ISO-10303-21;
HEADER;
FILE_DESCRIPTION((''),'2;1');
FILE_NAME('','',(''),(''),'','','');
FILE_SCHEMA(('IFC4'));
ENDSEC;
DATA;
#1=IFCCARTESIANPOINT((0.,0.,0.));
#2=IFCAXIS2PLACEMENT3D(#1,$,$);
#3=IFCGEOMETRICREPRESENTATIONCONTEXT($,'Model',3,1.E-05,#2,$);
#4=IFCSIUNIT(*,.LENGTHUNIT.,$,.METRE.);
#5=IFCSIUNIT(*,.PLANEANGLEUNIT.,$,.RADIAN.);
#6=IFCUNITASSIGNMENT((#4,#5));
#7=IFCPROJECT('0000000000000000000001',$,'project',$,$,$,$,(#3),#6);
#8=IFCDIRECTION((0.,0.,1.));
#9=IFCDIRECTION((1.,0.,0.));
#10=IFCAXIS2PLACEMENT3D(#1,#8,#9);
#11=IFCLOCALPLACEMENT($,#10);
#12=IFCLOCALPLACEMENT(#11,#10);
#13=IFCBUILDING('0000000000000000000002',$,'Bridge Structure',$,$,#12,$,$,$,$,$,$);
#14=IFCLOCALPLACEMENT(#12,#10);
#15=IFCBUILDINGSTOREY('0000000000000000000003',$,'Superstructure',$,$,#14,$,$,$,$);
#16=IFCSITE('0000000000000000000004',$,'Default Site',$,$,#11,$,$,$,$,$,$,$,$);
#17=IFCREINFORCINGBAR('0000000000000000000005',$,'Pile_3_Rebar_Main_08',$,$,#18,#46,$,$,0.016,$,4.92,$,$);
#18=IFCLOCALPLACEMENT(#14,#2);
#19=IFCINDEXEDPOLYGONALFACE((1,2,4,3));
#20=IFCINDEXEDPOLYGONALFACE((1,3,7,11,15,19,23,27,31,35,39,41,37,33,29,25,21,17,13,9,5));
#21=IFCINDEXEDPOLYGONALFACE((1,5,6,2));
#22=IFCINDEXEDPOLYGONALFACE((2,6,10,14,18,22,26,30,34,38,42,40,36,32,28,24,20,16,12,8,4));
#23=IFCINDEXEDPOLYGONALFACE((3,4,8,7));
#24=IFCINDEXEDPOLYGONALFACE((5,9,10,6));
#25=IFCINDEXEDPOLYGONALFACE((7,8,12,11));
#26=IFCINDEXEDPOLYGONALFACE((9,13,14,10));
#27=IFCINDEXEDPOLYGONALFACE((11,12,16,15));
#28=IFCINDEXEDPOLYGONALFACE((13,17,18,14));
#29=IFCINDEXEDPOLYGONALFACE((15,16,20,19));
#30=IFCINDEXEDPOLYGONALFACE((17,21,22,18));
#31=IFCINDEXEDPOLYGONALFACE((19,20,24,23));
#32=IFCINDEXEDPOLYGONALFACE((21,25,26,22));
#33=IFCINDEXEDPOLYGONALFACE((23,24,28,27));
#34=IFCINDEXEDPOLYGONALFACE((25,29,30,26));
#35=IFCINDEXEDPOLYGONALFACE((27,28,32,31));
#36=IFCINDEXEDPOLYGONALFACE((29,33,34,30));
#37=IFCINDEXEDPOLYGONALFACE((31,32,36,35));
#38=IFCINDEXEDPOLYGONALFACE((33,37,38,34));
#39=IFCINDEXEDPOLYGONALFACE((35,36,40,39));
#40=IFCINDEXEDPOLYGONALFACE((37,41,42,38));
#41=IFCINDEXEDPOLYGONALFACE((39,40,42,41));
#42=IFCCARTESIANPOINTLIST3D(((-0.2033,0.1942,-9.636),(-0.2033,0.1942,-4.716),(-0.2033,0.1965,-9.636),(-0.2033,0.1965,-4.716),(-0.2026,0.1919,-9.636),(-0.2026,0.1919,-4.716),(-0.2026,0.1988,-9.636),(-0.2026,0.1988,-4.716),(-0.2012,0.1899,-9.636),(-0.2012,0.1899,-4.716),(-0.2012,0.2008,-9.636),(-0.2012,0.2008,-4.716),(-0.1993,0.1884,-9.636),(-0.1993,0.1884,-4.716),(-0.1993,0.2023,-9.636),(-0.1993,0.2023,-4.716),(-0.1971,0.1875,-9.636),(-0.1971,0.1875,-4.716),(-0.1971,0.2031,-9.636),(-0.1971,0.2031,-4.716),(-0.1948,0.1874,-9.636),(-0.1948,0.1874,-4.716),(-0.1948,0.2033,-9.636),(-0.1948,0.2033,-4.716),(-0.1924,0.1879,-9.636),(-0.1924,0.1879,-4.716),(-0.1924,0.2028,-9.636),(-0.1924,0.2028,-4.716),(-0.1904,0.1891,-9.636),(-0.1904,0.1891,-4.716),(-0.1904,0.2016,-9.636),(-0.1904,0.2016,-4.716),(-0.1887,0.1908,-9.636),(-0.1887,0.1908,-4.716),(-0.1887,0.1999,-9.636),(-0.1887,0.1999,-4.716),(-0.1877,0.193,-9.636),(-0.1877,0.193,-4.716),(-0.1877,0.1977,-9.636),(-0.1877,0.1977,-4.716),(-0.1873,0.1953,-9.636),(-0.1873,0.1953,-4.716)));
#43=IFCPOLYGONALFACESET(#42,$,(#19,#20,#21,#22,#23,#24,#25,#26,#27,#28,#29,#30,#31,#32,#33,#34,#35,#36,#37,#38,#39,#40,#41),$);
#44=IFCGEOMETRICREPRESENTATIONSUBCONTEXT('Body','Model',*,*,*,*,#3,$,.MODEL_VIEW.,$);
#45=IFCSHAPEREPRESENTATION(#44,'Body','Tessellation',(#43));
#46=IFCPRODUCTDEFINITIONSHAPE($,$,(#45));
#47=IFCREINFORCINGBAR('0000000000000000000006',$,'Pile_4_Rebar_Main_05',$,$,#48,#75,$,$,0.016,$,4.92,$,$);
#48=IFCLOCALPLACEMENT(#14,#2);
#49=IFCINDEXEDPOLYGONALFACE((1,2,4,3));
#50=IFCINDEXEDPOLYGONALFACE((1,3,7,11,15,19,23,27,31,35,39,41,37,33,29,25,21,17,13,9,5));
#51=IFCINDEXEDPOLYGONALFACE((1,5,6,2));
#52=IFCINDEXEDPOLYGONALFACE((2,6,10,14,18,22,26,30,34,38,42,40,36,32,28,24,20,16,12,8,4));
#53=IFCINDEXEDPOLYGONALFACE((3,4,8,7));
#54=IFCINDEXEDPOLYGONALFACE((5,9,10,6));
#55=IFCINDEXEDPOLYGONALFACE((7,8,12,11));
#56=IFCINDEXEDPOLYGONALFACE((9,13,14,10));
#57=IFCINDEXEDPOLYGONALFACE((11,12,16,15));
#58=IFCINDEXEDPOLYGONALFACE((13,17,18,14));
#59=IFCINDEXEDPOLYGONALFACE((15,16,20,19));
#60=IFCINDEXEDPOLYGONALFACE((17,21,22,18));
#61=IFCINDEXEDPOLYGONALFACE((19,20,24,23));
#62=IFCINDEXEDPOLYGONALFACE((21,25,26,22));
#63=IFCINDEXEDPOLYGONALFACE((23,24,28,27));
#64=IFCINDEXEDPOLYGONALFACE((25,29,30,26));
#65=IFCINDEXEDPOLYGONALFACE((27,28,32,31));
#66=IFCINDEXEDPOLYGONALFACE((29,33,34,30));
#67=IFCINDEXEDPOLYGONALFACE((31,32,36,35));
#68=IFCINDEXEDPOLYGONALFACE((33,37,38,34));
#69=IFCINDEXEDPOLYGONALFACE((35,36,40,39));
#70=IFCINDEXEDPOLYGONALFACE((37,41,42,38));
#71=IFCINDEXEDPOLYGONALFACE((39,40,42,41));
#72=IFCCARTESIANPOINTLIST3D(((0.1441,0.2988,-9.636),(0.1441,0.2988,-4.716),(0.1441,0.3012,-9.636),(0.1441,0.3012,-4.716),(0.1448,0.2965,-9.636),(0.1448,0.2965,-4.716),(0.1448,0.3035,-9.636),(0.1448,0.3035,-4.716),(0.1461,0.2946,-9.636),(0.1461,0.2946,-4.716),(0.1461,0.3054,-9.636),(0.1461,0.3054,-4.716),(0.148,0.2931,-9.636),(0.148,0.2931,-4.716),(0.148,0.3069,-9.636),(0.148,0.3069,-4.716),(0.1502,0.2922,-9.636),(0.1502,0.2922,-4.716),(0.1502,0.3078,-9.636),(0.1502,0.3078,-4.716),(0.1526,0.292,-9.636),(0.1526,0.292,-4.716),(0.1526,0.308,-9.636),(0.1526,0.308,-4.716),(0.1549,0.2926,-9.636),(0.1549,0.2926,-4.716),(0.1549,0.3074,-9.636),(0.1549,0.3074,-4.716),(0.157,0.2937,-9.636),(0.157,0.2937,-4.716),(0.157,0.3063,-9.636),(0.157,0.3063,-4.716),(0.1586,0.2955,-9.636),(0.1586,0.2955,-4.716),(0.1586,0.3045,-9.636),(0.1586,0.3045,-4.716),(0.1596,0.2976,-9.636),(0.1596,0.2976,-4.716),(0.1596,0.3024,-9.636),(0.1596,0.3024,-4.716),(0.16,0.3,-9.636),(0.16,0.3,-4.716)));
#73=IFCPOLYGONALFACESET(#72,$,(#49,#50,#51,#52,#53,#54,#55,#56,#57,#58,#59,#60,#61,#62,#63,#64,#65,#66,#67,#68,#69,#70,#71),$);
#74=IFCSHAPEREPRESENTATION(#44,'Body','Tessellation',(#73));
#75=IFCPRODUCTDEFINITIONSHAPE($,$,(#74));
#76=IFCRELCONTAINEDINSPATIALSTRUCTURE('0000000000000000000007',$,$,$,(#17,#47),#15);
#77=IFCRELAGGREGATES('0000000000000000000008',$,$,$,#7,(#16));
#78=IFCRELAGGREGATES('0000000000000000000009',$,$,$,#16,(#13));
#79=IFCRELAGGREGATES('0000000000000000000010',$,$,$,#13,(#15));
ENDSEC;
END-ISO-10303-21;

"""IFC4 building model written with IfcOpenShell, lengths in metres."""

from ifc_helpers import new_model, si_unit, frame, origin, origin_with_axes, origin_2d_with_axis, place, context, subcontext, project, spatial, circle, extrude, element, save


model = new_model("IFC4")

# Units and contexts
model_context = context("Model", 3, precision=1e-05, world=origin())
body_context = subcontext(model_context, "Body", "Model", "MODEL_VIEW")
ifc_project = project(units=[si_unit("LENGTHUNIT", "METRE"), si_unit("PLANEANGLEUNIT", "RADIAN")], contexts=[model_context])

# Site, building, storey
site_placement = place(None, origin_with_axes())
site = spatial("IfcSite", under=ifc_project, at=site_placement, Name="Default Site")
building_placement = place(site_placement, origin_with_axes())
building = spatial("IfcBuilding", under=site, at=building_placement, Name="Bridge Structure")
storey_placement = place(building_placement, origin_with_axes())
storey = spatial("IfcBuildingStorey", under=building, at=storey_placement, Name="Superstructure")

# Reinforcing bars
for number, where, z_axis, x_axis, name in (
    (1, (-0.1953, 0.1953, -9.636), (0.0, 0.0, 1.0), (1.0, 0.0, 0.0), "Pile_3_Rebar_Main_08"),
    (2, (0.152, 0.3, -9.636), (0.0, 0.0, 1.0), (1.0, 0.0, 0.0), "Pile_4_Rebar_Main_05"),
):
    element("IfcReinforcingBar", number, at=place(storey_placement, frame(where, z_axis=z_axis, x_axis=x_axis)), inside=storey, Name=name, BarLength=4.92, NominalDiameter=0.016, context=body_context, shape_type="SweptSolid", body=[
        extrude(circle(Radius=0.008, at=origin_2d_with_axis()), origin_with_axes(), (0.0, 0.0, 1.0), 4.92),
    ])

save(model, "model.ifc")
